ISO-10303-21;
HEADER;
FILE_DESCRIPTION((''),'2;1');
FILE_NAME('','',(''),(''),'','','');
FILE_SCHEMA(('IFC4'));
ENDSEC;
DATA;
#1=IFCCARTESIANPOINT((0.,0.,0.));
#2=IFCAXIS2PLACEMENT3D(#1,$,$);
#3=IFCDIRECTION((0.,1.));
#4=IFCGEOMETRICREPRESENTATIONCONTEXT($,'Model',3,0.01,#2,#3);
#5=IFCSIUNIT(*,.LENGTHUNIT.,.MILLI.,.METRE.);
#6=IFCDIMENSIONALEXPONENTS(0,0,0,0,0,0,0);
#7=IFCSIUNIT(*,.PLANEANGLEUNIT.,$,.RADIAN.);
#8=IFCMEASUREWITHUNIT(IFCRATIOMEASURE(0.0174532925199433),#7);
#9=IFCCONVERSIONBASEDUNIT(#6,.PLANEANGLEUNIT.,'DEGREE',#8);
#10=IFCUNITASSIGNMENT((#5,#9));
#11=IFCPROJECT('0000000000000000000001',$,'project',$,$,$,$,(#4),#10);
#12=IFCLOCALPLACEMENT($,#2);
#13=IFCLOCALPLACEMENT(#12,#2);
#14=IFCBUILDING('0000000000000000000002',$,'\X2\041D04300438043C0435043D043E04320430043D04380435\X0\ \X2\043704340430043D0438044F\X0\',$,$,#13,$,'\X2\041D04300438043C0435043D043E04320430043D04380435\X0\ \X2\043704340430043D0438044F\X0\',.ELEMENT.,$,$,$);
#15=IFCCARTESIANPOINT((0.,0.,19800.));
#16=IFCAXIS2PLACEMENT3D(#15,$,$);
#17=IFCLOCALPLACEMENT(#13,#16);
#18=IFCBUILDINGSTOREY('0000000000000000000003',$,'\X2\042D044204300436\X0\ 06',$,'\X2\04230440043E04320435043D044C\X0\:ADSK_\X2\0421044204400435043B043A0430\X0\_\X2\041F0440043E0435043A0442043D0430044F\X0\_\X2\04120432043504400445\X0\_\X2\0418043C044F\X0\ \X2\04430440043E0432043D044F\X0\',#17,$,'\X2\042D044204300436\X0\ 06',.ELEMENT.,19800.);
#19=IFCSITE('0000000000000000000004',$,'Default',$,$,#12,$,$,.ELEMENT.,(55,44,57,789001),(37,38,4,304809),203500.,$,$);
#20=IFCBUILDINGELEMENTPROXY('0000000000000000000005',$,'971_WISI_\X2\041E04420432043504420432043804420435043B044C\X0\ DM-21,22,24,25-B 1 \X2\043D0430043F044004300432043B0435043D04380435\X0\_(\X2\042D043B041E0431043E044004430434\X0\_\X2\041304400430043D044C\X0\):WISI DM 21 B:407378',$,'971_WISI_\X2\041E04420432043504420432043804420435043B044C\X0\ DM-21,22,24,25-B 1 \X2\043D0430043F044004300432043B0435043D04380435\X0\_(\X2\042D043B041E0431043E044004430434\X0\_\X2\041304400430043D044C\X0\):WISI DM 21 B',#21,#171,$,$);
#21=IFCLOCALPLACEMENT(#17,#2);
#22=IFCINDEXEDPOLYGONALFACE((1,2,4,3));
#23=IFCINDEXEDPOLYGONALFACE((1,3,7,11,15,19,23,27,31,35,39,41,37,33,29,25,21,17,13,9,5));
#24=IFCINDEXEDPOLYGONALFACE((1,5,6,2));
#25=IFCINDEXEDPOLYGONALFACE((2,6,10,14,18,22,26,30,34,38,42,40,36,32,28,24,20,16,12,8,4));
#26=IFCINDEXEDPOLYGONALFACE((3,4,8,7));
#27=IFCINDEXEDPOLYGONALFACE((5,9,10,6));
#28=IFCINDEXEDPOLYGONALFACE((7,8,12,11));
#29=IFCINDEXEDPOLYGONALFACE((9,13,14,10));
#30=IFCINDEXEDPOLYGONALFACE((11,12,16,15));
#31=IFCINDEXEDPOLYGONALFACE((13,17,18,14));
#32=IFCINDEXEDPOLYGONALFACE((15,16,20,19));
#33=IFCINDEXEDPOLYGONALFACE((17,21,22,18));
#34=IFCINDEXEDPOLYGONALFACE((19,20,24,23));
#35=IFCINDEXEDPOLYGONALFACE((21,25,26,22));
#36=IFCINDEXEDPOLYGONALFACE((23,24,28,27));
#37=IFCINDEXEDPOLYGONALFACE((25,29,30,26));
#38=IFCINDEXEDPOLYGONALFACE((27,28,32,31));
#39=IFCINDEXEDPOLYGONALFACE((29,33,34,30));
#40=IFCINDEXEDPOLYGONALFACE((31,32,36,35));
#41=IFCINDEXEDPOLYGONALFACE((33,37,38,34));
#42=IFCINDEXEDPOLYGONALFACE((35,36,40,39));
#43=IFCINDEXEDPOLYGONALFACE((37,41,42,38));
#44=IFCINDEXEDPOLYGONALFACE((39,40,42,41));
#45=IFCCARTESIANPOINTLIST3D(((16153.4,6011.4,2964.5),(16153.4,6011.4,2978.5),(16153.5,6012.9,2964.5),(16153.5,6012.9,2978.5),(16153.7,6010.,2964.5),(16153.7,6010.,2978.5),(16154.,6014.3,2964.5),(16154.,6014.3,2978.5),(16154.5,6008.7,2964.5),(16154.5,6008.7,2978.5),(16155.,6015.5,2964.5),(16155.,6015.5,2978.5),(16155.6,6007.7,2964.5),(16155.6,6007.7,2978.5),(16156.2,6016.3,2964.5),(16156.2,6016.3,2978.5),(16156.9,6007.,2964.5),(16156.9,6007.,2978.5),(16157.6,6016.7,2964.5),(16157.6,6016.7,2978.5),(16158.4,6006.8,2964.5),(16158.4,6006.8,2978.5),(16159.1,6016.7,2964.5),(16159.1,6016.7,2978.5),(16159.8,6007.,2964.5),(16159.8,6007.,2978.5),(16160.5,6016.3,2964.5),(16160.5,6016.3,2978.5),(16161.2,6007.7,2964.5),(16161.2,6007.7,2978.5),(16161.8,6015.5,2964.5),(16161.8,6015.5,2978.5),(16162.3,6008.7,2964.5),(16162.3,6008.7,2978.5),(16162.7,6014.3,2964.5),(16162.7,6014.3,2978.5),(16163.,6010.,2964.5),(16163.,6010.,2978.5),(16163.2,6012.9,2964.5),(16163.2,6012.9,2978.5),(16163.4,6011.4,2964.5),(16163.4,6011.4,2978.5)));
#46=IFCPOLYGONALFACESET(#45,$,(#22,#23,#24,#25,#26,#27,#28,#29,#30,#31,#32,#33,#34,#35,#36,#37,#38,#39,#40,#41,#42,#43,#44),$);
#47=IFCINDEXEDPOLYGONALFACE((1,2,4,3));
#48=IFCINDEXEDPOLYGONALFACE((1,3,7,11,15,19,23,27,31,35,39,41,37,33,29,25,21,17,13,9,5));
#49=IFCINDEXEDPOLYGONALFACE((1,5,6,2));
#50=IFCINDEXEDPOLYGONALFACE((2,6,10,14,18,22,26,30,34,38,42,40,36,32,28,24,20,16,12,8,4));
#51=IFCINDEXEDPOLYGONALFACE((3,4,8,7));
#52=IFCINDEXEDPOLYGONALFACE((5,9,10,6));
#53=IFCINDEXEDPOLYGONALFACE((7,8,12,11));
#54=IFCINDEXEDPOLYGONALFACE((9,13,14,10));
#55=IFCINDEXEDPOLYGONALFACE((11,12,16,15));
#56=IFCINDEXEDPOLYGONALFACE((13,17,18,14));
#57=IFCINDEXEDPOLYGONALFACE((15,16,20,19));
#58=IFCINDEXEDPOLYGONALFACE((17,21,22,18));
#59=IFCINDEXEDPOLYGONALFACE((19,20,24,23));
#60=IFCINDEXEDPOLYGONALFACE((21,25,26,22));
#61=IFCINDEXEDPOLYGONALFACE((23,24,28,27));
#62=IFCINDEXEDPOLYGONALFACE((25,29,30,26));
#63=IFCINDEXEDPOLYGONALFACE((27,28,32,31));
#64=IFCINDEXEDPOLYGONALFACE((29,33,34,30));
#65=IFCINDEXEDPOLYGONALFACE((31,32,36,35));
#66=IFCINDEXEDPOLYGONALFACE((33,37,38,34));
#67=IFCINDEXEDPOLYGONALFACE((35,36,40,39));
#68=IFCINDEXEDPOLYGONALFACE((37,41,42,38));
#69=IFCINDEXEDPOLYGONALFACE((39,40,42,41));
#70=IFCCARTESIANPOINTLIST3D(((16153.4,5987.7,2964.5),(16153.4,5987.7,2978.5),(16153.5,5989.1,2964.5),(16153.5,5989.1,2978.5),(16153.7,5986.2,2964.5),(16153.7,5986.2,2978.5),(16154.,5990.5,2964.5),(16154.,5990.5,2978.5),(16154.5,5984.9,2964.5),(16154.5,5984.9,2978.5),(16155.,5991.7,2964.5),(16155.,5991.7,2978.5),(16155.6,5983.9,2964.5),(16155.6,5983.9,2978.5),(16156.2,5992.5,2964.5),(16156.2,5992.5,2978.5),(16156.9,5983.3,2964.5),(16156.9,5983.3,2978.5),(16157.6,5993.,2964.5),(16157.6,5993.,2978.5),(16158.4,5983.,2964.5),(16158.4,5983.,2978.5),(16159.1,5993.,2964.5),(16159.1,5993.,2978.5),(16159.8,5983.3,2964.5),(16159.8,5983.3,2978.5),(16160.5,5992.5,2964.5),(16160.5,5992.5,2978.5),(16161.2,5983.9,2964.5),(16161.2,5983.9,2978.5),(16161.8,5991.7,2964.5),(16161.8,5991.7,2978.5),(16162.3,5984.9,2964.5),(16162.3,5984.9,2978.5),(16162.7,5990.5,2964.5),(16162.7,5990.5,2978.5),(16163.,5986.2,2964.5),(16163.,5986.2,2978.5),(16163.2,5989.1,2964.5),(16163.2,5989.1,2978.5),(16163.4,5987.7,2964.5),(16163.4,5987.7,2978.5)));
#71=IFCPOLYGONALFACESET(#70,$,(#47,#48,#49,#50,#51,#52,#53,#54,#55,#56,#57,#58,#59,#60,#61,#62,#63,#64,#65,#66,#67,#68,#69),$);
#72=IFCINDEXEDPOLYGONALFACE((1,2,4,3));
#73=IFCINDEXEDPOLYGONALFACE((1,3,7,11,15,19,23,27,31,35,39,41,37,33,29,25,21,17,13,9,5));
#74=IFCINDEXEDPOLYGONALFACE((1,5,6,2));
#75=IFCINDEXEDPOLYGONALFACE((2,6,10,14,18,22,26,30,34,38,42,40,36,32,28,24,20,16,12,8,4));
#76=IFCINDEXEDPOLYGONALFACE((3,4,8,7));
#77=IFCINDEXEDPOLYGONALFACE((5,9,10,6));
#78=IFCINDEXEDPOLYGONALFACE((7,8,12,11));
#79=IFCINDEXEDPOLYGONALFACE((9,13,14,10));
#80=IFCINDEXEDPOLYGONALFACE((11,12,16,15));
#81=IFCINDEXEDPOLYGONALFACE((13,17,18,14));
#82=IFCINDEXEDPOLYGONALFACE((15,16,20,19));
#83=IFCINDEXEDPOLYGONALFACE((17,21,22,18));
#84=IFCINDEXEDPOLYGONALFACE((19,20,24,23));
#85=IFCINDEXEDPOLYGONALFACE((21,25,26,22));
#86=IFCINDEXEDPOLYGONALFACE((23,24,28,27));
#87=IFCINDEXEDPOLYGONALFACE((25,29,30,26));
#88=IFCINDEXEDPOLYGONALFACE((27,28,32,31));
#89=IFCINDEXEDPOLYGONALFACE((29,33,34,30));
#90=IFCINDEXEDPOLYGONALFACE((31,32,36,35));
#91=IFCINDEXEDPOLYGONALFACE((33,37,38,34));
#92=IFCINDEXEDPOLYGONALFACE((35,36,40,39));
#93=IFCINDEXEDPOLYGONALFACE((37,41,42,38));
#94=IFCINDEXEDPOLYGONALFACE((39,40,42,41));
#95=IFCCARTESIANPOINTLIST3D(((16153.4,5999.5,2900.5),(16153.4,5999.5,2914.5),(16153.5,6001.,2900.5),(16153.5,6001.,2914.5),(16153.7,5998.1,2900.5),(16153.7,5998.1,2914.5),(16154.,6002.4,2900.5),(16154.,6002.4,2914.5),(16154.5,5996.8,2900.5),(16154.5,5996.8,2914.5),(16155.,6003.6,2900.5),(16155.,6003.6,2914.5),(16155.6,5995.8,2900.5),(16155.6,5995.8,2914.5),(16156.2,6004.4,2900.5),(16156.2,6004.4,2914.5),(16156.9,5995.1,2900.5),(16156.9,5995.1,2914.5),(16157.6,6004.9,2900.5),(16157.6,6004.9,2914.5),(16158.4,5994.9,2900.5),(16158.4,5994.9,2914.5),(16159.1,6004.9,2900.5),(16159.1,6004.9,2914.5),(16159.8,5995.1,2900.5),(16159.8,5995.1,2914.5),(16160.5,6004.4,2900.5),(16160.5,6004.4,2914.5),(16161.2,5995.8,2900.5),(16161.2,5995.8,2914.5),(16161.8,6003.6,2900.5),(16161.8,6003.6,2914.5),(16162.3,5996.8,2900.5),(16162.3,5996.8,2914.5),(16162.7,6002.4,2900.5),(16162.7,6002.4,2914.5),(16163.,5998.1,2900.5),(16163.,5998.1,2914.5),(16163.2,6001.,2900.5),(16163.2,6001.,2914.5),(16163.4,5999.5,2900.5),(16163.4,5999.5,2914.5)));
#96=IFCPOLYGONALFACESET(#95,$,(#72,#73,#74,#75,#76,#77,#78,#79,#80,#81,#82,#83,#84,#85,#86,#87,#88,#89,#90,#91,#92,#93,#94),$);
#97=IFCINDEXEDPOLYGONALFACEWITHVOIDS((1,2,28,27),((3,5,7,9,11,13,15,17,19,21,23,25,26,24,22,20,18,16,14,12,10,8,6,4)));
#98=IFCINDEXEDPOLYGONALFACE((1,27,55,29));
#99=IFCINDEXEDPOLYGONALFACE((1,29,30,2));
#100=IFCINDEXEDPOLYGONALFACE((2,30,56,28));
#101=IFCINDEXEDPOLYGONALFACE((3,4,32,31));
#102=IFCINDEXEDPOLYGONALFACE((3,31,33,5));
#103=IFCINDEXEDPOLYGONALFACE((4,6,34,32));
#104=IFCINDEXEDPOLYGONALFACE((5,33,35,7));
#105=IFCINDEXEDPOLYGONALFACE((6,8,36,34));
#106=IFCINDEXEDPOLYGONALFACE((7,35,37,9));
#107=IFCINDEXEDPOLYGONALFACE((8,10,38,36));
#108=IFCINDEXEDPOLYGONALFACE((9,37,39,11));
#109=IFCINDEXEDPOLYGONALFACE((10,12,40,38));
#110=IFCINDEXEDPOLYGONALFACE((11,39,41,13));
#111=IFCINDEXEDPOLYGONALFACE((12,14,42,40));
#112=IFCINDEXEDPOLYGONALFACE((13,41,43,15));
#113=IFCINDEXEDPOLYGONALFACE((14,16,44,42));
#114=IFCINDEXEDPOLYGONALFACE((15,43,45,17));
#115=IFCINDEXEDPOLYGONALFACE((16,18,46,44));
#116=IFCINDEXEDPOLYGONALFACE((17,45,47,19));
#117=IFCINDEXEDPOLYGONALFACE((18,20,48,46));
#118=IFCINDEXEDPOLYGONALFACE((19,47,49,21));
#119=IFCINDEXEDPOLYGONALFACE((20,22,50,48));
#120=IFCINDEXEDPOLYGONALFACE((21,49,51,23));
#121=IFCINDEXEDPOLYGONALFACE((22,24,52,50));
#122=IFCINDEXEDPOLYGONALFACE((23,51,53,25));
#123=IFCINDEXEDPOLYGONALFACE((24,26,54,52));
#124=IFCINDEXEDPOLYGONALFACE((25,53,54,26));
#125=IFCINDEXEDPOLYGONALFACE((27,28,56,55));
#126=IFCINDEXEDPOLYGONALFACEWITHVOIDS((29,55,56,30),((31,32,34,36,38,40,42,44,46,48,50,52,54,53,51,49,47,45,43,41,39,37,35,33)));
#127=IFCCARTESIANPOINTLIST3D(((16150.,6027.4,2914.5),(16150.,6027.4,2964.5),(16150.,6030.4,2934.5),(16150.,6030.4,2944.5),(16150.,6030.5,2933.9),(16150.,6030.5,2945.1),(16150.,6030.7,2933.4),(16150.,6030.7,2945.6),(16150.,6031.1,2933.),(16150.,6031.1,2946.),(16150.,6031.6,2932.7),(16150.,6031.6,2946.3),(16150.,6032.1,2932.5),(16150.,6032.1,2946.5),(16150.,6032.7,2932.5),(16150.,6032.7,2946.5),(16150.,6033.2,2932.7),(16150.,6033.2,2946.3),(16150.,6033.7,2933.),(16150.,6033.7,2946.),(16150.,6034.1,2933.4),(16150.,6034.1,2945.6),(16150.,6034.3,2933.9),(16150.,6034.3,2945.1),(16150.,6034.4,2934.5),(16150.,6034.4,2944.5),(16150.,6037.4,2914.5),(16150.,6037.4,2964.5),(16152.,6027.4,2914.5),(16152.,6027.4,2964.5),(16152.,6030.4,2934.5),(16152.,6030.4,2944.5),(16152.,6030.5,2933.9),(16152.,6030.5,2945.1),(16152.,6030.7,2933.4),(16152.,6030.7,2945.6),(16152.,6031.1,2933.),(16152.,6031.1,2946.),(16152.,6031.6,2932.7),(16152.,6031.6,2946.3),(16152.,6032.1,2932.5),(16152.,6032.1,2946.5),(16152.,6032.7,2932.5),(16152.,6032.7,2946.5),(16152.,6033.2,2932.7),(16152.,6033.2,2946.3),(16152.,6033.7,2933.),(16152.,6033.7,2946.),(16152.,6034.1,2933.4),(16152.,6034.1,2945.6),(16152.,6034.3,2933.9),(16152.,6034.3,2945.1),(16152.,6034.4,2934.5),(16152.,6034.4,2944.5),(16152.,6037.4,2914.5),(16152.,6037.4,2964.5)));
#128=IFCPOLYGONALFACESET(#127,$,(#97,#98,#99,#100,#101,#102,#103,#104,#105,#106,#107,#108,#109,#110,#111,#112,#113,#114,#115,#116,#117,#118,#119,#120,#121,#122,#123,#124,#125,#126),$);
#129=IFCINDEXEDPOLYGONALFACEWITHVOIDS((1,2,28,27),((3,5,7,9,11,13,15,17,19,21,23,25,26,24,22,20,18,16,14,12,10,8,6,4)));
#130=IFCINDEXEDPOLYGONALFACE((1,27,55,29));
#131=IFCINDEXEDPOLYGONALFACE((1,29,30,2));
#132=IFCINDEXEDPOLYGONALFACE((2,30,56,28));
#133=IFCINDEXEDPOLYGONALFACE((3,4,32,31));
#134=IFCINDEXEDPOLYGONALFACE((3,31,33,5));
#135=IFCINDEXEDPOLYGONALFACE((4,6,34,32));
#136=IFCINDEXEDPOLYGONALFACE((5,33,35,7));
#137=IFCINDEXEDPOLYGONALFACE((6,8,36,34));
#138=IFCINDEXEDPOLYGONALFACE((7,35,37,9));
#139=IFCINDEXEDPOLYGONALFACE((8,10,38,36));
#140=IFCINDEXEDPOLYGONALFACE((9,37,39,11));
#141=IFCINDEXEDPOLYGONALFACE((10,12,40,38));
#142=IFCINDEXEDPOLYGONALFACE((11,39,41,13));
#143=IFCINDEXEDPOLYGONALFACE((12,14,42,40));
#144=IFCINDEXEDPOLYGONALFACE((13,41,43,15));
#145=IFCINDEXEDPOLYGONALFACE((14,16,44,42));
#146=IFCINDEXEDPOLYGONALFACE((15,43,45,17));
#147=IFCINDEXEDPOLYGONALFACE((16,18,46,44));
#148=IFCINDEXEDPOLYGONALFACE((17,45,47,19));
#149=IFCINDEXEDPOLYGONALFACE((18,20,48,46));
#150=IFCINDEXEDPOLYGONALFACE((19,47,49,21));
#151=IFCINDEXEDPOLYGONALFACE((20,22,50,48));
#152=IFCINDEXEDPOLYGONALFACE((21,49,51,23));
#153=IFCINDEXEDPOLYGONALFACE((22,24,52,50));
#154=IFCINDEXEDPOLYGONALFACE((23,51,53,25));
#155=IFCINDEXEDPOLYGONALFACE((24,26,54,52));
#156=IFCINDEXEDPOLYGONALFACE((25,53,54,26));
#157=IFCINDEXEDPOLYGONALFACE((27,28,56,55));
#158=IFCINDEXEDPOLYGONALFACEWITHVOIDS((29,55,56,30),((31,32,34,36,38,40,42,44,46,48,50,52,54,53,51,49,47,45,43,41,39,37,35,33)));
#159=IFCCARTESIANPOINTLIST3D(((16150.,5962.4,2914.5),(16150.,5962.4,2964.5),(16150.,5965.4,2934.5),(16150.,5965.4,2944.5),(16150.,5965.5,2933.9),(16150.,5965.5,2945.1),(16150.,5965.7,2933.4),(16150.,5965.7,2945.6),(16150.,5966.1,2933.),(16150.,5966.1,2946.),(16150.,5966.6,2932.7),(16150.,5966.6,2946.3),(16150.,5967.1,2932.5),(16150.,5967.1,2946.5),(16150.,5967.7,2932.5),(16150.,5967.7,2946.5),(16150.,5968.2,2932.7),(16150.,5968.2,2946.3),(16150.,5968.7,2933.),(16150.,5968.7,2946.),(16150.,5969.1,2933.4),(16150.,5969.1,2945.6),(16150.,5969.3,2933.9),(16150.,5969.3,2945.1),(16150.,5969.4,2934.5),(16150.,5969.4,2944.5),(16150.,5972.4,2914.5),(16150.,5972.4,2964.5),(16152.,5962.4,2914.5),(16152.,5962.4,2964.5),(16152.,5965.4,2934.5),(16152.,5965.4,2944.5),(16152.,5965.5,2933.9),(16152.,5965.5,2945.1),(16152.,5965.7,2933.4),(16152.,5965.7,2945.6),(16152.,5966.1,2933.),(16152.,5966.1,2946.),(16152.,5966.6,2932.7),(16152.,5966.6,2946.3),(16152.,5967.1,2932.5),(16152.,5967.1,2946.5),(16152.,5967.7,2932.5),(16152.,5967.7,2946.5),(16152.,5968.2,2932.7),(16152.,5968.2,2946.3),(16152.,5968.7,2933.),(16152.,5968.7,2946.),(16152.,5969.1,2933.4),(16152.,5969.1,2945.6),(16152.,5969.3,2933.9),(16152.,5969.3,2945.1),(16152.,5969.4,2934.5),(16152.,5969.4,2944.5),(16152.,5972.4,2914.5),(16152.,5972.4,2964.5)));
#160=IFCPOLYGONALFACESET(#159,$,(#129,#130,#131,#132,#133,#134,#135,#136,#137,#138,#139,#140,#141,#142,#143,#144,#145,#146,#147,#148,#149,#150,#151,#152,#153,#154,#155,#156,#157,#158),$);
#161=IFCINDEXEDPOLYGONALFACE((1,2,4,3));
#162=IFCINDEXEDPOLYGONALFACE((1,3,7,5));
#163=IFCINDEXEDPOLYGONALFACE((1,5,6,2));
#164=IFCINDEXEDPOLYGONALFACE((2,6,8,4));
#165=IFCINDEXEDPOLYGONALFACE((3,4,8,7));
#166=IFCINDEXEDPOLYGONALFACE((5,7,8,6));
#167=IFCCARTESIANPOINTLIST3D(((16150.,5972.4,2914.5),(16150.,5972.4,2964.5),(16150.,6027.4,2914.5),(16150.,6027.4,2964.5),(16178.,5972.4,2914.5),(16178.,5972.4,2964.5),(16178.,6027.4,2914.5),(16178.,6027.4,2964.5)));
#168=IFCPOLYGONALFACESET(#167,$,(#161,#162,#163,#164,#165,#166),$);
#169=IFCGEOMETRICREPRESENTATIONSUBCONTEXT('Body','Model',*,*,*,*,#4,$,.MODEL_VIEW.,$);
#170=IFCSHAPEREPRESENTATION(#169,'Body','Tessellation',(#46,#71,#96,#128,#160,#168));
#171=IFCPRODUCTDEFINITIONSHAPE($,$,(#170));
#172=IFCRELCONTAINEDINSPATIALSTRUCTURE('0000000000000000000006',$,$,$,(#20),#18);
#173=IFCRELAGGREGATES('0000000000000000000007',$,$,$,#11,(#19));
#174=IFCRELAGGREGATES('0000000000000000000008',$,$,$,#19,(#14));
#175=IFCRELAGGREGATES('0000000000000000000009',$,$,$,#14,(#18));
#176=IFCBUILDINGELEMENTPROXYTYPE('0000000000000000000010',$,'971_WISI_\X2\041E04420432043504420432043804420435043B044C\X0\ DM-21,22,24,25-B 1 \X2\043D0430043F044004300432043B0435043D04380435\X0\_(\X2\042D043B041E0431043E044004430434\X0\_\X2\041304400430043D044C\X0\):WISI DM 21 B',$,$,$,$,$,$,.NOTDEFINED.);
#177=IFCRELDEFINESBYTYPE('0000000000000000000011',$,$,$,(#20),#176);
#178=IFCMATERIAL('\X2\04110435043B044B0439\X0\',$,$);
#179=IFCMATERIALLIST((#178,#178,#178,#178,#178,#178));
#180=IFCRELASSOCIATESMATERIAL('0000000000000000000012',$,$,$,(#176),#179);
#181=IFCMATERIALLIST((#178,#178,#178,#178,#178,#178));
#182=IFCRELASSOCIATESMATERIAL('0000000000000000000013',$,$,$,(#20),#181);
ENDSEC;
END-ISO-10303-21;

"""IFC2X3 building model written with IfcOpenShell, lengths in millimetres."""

from ifc_helpers import new_model, entity, si_unit, converted_unit, direction, frame, frame_2d, origin, place, context, subcontext, project, spatial, polyline, circle_curve, parameter, trimmed, segment, composite_curve, rectangle, circle, outline, extrude, source, transform, mapped, material, material_list, type_object, type_shapes, element, save


model = new_model("IFC2X3")

# Units and contexts
model_context = context("Model", 3, precision=0.01, world=origin(), true_north=direction((0.0, 1.0)))
body_context = subcontext(model_context, "Body", "Model", "MODEL_VIEW")
ifc_project = project(units=[si_unit("LENGTHUNIT", "METRE", prefix="MILLI"), converted_unit("PLANEANGLEUNIT", "DEGREE", entity("IfcRatioMeasure", 0.0174532925199433), si_unit("PLANEANGLEUNIT", "RADIAN"), dimensions=[0, 0, 0, 0, 0, 0, 0])], contexts=[model_context])

# Site, building, storey
site_placement = place(None, frame((0.0, 0.0, 0.0)))
site = spatial("IfcSite", under=ifc_project, at=site_placement, Name="Default", CompositionType="ELEMENT", RefLatitude=(55, 44, 57, 789001), RefLongitude=(37, 38, 4, 304809), RefElevation=203500.0)
building_placement = place(site_placement, origin())
building = spatial("IfcBuilding", under=site, at=building_placement, Name="Наименование здания", LongName="Наименование здания", CompositionType="ELEMENT")
storey_placement = place(building_placement, frame((0.0, 0.0, 19800.0)))
storey = spatial("IfcBuildingStorey", under=building, at=storey_placement, Name="Этаж 06", ObjectType="Уровень:ADSK_Стрелка_Проектная_Вверх_Имя уровня", LongName="Этаж 06", CompositionType="ELEMENT", Elevation=19800.0)

# Building element proxy
ifc_material_1 = material(Name="Белый")
ifc_material_list_1 = material_list([ifc_material_1, ifc_material_1, ifc_material_1, ifc_material_1, ifc_material_1, ifc_material_1])
ifc_material_list_2 = material_list([ifc_material_1, ifc_material_1, ifc_material_1, ifc_material_1, ifc_material_1, ifc_material_1])
building_element_proxy_type_1 = type_object("IfcBuildingElementProxyType", Name="971_WISI_Ответвитель DM-21,22,24,25-B 1 направление_(ЭлОборуд_Грань):WISI DM 21 B", PredefinedType="NOTDEFINED", material=ifc_material_list_2)
shared_shape_1 = source(origin(), body_context, "Body", "SweptSolid", [
    extrude(circle(Radius=5.0, at=frame_2d((0.0, 0.0), x_axis=(1.0, 0.0))), frame((11.9, 25.0, 8.4), z_axis=(0.0, 1.0, 0.0), x_axis=(-1.0, 0.0, 0.0)), (0.0, 0.0, 1.0), 14.0),
    extrude(circle(Radius=5.0, at=frame_2d((0.0, 0.0), x_axis=(1.0, 0.0))), frame((-11.8, 25.0, 8.4), z_axis=(0.0, 1.0, 0.0), x_axis=(-1.0, 0.0, 0.0)), (0.0, 0.0, 1.0), 14.0),
    extrude(circle(Radius=5.0, at=frame_2d((0.0, 0.0), x_axis=(1.0, 0.0))), frame((0.0, -39.0, 8.4), z_axis=(0.0, 1.0, 0.0), x_axis=(-1.0, 0.0, 0.0)), (0.0, 0.0, 1.0), 14.0),
    extrude(outline(polyline([(-5.0, -25.0), (5.0, -25.0), (5.0, 25.0), (-5.0, 25.0), (-5.0, -25.0)]), holes=[composite_curve([segment(polyline([(2.0, 5.0), (2.0, -5.0)]), True, "CONTINUOUS"), segment(trimmed(circle_curve(frame_2d((0.0, -5.0), x_axis=(-1.0, 0.0)), 2.0), [parameter(0.0)], [parameter(180.0)], True, "PARAMETER"), False, "CONTINUOUS"), segment(polyline([(-2.0, -5.0), (-2.0, 5.0)]), True, "CONTINUOUS"), segment(trimmed(circle_curve(frame_2d((0.0, 5.0), x_axis=(-1.0, 0.0)), 2.0), [parameter(180.0)], [parameter(0.0)], True, "PARAMETER"), False, "CONTINUOUS")], self_intersect=False)]), frame((32.5, 0.0, 0.0), z_axis=(0.0, 0.0, 1.0), x_axis=(-1.0, 0.0, 0.0)), (0.0, 0.0, 1.0), 2.0),
    extrude(outline(polyline([(-5.0, -25.0), (5.0, -25.0), (5.0, 25.0), (-5.0, 25.0), (-5.0, -25.0)]), holes=[composite_curve([segment(polyline([(-2.0, -5.0), (-2.0, 5.0)]), True, "CONTINUOUS"), segment(trimmed(circle_curve(frame_2d((0.0, 5.0), x_axis=(-1.0, 0.0)), 2.0), [parameter(180.0)], [parameter(0.0)], True, "PARAMETER"), False, "CONTINUOUS"), segment(polyline([(2.0, 5.0), (2.0, -5.0)]), True, "CONTINUOUS"), segment(trimmed(circle_curve(frame_2d((0.0, -5.0), x_axis=(-1.0, 0.0)), 2.0), [parameter(0.0)], [parameter(180.0)], True, "PARAMETER"), False, "CONTINUOUS")], self_intersect=False)]), frame((-32.5, 0.0, 0.0), z_axis=(0.0, 0.0, 1.0), x_axis=(-1.0, 0.0, 0.0)), (0.0, 0.0, 1.0), 2.0),
    extrude(rectangle(XDim=55.0, YDim=50.0, at=frame_2d((0.0, 0.0), x_axis=(1.0, 0.0))), frame((0.0, 0.0, 0.0), z_axis=(0.0, 0.0, 1.0), x_axis=(-1.0, 0.0, 0.0)), (0.0, 0.0, 1.0), 28.0),
])
type_shapes(building_element_proxy_type_1, [shared_shape_1])
proxy_1_placement = place(storey_placement, frame((16150.0, 5999.9, 2939.5), z_axis=(1.0, 0.0, 0.0), x_axis=(0.0, 1.0, 0.0)))
element("IfcBuildingElementProxy", 1, at=proxy_1_placement, inside=storey, type_object=building_element_proxy_type_1, material=ifc_material_list_1, Name="971_WISI_Ответвитель DM-21,22,24,25-B 1 направление_(ЭлОборуд_Грань):WISI DM 21 B:407378", ObjectType="971_WISI_Ответвитель DM-21,22,24,25-B 1 направление_(ЭлОборуд_Грань):WISI DM 21 B", context=body_context, shape_type="MappedRepresentation", body=[
    mapped(shared_shape_1, transform((0.0, 0.0, 0.0), scale=1.0)),
])

save(model, "model.ifc")
